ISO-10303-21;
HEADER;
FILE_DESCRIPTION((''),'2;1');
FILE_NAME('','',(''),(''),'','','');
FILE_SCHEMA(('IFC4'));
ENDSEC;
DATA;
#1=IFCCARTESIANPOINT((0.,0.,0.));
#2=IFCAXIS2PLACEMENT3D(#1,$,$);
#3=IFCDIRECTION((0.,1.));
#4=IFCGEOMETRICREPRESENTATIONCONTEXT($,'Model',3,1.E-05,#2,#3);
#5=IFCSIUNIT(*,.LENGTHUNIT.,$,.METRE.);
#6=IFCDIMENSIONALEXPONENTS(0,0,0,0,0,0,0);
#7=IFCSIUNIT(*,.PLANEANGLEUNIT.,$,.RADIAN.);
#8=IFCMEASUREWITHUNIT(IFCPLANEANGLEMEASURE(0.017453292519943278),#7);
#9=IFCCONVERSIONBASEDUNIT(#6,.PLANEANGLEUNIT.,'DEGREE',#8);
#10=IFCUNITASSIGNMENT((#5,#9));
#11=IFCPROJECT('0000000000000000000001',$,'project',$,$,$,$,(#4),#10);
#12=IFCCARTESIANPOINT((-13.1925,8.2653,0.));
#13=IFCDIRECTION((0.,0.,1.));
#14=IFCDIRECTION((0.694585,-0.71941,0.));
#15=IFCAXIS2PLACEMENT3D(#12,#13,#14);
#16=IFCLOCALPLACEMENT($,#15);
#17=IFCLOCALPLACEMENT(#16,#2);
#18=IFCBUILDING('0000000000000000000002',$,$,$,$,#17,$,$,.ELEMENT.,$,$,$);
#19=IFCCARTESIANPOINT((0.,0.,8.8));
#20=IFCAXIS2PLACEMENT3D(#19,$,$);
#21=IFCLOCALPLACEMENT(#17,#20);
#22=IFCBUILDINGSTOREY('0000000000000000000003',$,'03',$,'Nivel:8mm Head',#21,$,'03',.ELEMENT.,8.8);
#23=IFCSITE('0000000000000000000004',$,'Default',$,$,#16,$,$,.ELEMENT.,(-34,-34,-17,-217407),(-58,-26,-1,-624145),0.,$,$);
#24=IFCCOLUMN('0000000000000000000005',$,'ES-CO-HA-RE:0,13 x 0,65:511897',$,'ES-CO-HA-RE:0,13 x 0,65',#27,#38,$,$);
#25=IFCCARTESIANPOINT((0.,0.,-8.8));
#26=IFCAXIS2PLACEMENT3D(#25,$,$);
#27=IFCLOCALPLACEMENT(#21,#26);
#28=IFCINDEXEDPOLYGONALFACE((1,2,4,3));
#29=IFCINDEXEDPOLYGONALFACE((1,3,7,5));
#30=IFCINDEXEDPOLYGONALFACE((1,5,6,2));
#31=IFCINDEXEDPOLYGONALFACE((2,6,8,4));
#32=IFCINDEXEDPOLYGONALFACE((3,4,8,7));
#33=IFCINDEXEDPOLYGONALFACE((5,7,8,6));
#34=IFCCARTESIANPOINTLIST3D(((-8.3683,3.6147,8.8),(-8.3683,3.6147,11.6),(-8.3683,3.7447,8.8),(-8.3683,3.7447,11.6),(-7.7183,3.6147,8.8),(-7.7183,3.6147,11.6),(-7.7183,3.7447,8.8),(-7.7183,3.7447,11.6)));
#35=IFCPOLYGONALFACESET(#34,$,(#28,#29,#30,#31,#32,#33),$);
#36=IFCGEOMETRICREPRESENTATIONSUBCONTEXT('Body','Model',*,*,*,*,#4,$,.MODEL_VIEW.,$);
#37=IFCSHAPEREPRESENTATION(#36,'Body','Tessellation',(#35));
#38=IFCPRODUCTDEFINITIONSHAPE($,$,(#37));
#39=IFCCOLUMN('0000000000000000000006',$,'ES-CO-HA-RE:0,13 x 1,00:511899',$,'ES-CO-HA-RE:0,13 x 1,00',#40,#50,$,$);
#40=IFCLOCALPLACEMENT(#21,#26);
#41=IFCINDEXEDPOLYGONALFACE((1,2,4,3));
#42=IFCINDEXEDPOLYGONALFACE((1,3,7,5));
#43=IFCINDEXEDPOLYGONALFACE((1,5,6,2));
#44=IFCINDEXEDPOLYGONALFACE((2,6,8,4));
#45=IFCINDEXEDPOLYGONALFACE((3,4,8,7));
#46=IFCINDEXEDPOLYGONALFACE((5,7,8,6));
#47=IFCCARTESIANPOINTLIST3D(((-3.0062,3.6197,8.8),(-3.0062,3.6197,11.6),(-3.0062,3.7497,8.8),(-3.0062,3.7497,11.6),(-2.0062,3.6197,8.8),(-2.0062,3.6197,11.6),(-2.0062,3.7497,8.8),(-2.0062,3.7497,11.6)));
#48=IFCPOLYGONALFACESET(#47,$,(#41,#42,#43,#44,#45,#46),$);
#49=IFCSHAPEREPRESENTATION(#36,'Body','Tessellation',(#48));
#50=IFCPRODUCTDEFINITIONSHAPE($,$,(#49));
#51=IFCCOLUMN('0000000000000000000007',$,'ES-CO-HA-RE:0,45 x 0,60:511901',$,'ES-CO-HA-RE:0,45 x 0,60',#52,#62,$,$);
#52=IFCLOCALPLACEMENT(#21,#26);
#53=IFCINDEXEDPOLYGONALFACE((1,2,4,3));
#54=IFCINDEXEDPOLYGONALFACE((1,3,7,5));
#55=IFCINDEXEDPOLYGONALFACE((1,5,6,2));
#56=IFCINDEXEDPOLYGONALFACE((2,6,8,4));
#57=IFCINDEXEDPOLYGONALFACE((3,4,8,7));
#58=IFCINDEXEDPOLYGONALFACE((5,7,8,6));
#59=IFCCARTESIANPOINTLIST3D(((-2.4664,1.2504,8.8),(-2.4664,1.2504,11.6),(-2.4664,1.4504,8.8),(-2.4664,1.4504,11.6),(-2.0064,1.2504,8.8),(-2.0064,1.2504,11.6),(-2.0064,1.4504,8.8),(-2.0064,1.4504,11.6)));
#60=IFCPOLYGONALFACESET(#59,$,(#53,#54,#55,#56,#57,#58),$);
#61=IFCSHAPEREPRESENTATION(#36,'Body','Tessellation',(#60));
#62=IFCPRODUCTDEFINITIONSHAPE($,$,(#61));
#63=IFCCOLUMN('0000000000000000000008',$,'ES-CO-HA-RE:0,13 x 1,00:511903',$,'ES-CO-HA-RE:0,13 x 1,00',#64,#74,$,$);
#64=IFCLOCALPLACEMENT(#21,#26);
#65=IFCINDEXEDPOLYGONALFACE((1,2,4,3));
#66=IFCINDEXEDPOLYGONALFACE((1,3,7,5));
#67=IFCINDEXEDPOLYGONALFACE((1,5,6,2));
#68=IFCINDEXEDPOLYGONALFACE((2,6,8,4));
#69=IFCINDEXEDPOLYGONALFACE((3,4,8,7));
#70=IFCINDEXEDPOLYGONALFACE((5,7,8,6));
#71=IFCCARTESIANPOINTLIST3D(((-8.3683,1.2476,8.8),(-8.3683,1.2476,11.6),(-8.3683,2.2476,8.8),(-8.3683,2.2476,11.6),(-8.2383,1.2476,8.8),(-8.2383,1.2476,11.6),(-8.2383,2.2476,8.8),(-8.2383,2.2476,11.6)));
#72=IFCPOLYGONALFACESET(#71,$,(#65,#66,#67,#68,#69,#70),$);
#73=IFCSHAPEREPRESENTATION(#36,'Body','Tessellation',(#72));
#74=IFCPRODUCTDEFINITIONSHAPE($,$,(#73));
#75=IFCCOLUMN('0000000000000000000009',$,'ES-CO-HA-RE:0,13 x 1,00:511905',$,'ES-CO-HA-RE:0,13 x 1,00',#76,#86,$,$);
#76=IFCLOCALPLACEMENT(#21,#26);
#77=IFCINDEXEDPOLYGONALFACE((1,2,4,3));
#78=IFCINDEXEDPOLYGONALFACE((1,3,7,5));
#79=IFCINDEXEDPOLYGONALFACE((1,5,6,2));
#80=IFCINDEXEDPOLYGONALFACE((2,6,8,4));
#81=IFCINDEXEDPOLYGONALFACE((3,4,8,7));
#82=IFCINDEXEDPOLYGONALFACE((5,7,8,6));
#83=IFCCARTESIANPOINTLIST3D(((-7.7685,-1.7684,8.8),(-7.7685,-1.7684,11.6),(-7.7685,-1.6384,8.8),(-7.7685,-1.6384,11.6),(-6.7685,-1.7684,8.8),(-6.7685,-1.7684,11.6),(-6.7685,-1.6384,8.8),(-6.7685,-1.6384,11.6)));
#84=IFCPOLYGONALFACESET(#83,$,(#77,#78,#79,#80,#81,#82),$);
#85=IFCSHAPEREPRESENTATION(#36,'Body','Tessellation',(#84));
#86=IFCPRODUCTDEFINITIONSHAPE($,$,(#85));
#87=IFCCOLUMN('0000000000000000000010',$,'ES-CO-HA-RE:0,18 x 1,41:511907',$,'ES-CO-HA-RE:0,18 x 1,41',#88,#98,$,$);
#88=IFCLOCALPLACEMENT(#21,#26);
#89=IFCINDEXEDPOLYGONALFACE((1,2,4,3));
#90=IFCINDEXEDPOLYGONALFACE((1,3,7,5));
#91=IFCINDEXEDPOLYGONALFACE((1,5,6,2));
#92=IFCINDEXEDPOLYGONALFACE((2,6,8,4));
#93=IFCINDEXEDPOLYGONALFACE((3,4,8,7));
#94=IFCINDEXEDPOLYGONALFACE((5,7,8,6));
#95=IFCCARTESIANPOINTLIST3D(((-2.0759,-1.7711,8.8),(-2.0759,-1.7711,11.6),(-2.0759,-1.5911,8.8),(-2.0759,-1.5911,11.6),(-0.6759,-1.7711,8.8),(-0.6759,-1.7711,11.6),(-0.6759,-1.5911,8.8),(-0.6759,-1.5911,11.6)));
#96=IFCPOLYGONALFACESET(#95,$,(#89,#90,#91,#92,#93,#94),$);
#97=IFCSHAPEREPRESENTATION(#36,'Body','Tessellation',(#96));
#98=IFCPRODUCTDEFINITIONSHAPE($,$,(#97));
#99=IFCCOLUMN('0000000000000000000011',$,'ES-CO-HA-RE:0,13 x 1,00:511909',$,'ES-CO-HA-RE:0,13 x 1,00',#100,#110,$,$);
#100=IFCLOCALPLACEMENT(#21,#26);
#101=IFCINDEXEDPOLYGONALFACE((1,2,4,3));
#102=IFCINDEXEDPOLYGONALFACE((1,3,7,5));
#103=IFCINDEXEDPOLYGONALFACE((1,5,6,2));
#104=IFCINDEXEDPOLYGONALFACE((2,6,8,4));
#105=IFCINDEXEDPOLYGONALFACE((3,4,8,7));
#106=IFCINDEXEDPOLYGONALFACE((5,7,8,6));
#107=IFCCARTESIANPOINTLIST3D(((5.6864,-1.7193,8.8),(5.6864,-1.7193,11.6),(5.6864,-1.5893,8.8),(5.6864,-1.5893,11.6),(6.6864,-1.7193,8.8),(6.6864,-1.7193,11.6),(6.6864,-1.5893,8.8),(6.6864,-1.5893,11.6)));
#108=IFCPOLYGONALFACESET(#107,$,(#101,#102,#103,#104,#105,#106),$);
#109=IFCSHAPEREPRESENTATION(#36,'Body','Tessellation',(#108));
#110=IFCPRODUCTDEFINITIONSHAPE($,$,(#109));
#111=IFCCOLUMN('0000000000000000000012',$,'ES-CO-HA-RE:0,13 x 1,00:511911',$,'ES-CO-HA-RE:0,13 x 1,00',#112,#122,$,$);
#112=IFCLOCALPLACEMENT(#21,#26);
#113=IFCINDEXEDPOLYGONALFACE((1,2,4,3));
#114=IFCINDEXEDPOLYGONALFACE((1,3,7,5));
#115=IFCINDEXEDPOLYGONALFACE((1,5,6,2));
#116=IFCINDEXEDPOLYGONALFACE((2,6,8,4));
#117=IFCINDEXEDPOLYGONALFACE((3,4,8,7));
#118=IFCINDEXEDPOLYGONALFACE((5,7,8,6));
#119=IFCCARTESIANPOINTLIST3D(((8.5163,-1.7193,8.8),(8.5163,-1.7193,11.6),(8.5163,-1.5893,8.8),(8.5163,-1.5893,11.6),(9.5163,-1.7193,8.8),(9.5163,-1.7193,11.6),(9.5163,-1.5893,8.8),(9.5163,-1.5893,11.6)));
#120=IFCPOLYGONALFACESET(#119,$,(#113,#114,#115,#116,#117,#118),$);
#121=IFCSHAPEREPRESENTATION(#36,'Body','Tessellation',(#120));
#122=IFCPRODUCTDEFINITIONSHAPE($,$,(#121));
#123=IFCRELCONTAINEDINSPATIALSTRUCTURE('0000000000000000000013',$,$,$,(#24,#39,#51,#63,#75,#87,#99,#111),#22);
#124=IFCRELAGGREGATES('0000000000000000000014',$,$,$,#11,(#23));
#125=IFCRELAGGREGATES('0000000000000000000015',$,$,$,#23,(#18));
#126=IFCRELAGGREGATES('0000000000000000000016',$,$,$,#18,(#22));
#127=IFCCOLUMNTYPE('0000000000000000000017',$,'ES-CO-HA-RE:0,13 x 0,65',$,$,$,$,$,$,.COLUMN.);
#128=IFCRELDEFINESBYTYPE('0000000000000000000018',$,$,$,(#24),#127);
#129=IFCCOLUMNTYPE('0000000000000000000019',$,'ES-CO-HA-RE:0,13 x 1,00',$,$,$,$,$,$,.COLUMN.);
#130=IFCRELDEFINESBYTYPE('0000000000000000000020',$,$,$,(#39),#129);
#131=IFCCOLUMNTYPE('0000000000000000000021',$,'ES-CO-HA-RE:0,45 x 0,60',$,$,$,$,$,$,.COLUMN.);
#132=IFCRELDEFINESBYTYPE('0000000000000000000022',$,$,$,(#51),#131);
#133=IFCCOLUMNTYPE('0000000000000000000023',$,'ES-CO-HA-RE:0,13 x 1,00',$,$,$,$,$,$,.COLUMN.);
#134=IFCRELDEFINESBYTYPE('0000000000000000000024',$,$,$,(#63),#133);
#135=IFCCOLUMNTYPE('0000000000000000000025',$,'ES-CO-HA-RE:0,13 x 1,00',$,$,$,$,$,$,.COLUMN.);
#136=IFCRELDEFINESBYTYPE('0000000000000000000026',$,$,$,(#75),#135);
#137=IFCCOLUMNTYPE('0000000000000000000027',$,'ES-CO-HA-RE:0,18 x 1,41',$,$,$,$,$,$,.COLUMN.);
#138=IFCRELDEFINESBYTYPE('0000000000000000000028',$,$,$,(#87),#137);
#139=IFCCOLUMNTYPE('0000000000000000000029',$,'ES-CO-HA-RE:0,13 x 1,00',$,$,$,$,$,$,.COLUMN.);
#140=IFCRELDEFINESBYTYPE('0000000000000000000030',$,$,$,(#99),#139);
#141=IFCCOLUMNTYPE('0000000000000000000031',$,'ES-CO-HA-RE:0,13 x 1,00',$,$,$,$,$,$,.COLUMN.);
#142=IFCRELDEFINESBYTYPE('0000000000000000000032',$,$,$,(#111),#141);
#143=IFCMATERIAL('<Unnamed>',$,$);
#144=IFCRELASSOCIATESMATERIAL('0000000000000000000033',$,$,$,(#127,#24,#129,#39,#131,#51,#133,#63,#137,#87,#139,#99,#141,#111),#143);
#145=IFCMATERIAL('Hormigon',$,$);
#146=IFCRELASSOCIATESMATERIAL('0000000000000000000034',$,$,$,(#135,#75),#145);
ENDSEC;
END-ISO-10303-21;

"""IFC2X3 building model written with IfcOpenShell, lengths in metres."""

from ifc_helpers import new_model, entity, si_unit, converted_unit, direction, frame, frame_2d, origin, origin_2d_with_axis, place, context, subcontext, project, spatial, rectangle, extrude, source, transform, mapped, material, type_object, type_shapes, element, save


model = new_model("IFC2X3")

# Units and contexts
model_context = context("Model", 3, precision=1e-05, world=origin(), true_north=direction((0.0, 1.0)))
body_context = subcontext(model_context, "Body", "Model", "MODEL_VIEW")
ifc_project = project(units=[si_unit("LENGTHUNIT", "METRE"), converted_unit("PLANEANGLEUNIT", "DEGREE", entity("IfcPlaneAngleMeasure", 0.017453292519943278), si_unit("PLANEANGLEUNIT", "RADIAN"), dimensions=[0, 0, 0, 0, 0, 0, 0])], contexts=[model_context])

# Site, building, storey
site_placement = place(None, frame((-13.1925, 8.2653, 0.0), z_axis=(0.0, 0.0, 1.0), x_axis=(0.694585, -0.71941, 0.0)))
site = spatial("IfcSite", under=ifc_project, at=site_placement, Name="Default", CompositionType="ELEMENT", RefLatitude=(-34, -34, -17, -217407), RefLongitude=(-58, -26, -1, -624145), RefElevation=0.0)
building_placement = place(site_placement, origin())
building = spatial("IfcBuilding", under=site, at=building_placement, CompositionType="ELEMENT")
storey_placement = place(building_placement, frame((0.0, 0.0, 8.8)))
storey = spatial("IfcBuildingStorey", under=building, at=storey_placement, Name="03", ObjectType="Nivel:8mm Head", LongName="03", CompositionType="ELEMENT", Elevation=8.8)

# Columns
ifc_material_1 = material(Name="<Unnamed>")
column_type_1 = type_object("IfcColumnType", Name="ES-CO-HA-RE:0,13 x 0,65", PredefinedType="COLUMN", material=ifc_material_1)
shared_shape_1 = source(origin(), body_context, "Body", "SweptSolid", [
    extrude(rectangle(XDim=0.65, YDim=0.13, at=origin_2d_with_axis()), frame((-8.0433, 3.6797, 8.8), z_axis=(0.0, 0.0, 1.0), x_axis=(-1.0, 0.0, 0.0)), (0.0, 0.0, 1.0), 2.8),
])
type_shapes(column_type_1, [shared_shape_1])
column_1_placement = place(storey_placement, frame((0.0, 0.0, -8.8)))
element("IfcColumn", 1, at=column_1_placement, inside=storey, type_object=column_type_1, material=ifc_material_1, Name="ES-CO-HA-RE:0,13 x 0,65:511897", ObjectType="ES-CO-HA-RE:0,13 x 0,65", context=body_context, shape_type="MappedRepresentation", body=[
    mapped(shared_shape_1, transform((0.0, 0.0, 0.0), scale=1.0)),
])
column_type_2 = type_object("IfcColumnType", Name="ES-CO-HA-RE:0,13 x 1,00", PredefinedType="COLUMN", material=ifc_material_1)
shared_shape_2 = source(origin(), body_context, "Body", "SweptSolid", [
    extrude(rectangle(XDim=1.0, YDim=0.13, at=frame_2d((0.0, 0.0), x_axis=(1.0, 0.0))), frame((-2.5062, 3.6847, 8.8), z_axis=(0.0, 0.0, 1.0), x_axis=(-1.0, 0.0, 0.0)), (0.0, 0.0, 1.0), 2.8),
])
type_shapes(column_type_2, [shared_shape_2])
column_2_placement = place(storey_placement, frame((0.0, 0.0, -8.8)))
element("IfcColumn", 2, at=column_2_placement, inside=storey, type_object=column_type_2, material=ifc_material_1, Name="ES-CO-HA-RE:0,13 x 1,00:511899", ObjectType="ES-CO-HA-RE:0,13 x 1,00", context=body_context, shape_type="MappedRepresentation", body=[
    mapped(shared_shape_2, transform((0.0, 0.0, 0.0), scale=1.0)),
])
column_type_3 = type_object("IfcColumnType", Name="ES-CO-HA-RE:0,45 x 0,60", PredefinedType="COLUMN", material=ifc_material_1)
shared_shape_3 = source(origin(), body_context, "Body", "SweptSolid", [
    extrude(rectangle(XDim=0.46, YDim=0.2, at=frame_2d((0.0, 0.0), x_axis=(1.0, 0.0))), frame((-2.2364, 1.3504, 8.8), z_axis=(0.0, 0.0, 1.0), x_axis=(-1.0, 0.0, 0.0)), (0.0, 0.0, 1.0), 2.8),
])
type_shapes(column_type_3, [shared_shape_3])
column_3_placement = place(storey_placement, frame((0.0, 0.0, -8.8)))
element("IfcColumn", 3, at=column_3_placement, inside=storey, type_object=column_type_3, material=ifc_material_1, Name="ES-CO-HA-RE:0,45 x 0,60:511901", ObjectType="ES-CO-HA-RE:0,45 x 0,60", context=body_context, shape_type="MappedRepresentation", body=[
    mapped(shared_shape_3, transform((0.0, 0.0, 0.0), scale=1.0)),
])
column_type_4 = type_object("IfcColumnType", Name="ES-CO-HA-RE:0,13 x 1,00", PredefinedType="COLUMN", material=ifc_material_1)
shared_shape_4 = source(origin(), body_context, "Body", "SweptSolid", [
    extrude(rectangle(XDim=1.0, YDim=0.13, at=frame_2d((0.0, 0.0), x_axis=(1.0, 0.0))), frame((-8.3033, 1.7476, 8.8), z_axis=(0.0, 0.0, 1.0), x_axis=(0.0, -1.0, 0.0)), (0.0, 0.0, 1.0), 2.8),
])
type_shapes(column_type_4, [shared_shape_4])
column_4_placement = place(storey_placement, frame((0.0, 0.0, -8.8)))
element("IfcColumn", 4, at=column_4_placement, inside=storey, type_object=column_type_4, material=ifc_material_1, Name="ES-CO-HA-RE:0,13 x 1,00:511903", ObjectType="ES-CO-HA-RE:0,13 x 1,00", context=body_context, shape_type="MappedRepresentation", body=[
    mapped(shared_shape_4, transform((0.0, 0.0, 0.0), scale=1.0)),
])
ifc_material_2 = material(Name="Hormigon")
column_type_5 = type_object("IfcColumnType", Name="ES-CO-HA-RE:0,13 x 1,00", PredefinedType="COLUMN", material=ifc_material_2)
shared_shape_5 = source(origin(), body_context, "Body", "SweptSolid", [
    extrude(rectangle(XDim=1.0, YDim=0.13, at=frame_2d((0.0, 0.0), x_axis=(1.0, 0.0))), frame((-7.2685, -1.7034, 8.8), z_axis=(0.0, 0.0, 1.0), x_axis=(-1.0, 0.0, 0.0)), (0.0, 0.0, 1.0), 2.8),
])
type_shapes(column_type_5, [shared_shape_5])
column_5_placement = place(storey_placement, frame((0.0, 0.0, -8.8)))
element("IfcColumn", 5, at=column_5_placement, inside=storey, type_object=column_type_5, material=ifc_material_2, Name="ES-CO-HA-RE:0,13 x 1,00:511905", ObjectType="ES-CO-HA-RE:0,13 x 1,00", context=body_context, shape_type="MappedRepresentation", body=[
    mapped(shared_shape_5, transform((0.0, 0.0, 0.0), scale=1.0)),
])
column_type_6 = type_object("IfcColumnType", Name="ES-CO-HA-RE:0,18 x 1,41", PredefinedType="COLUMN", material=ifc_material_1)
shared_shape_6 = source(origin(), body_context, "Body", "SweptSolid", [
    extrude(rectangle(XDim=1.4, YDim=0.18, at=frame_2d((0.0, 0.0), x_axis=(1.0, 0.0))), frame((-1.3759, -1.6811, 8.8), z_axis=(0.0, 0.0, 1.0), x_axis=(-1.0, 0.0, 0.0)), (0.0, 0.0, 1.0), 2.8),
])
type_shapes(column_type_6, [shared_shape_6])
column_6_placement = place(storey_placement, frame((0.0, 0.0, -8.8)))
element("IfcColumn", 6, at=column_6_placement, inside=storey, type_object=column_type_6, material=ifc_material_1, Name="ES-CO-HA-RE:0,18 x 1,41:511907", ObjectType="ES-CO-HA-RE:0,18 x 1,41", context=body_context, shape_type="MappedRepresentation", body=[
    mapped(shared_shape_6, transform((0.0, 0.0, 0.0), scale=1.0)),
])
column_type_7 = type_object("IfcColumnType", Name="ES-CO-HA-RE:0,13 x 1,00", PredefinedType="COLUMN", material=ifc_material_1)
shared_shape_7 = source(origin(), body_context, "Body", "SweptSolid", [
    extrude(rectangle(XDim=1.0, YDim=0.13, at=frame_2d((0.0, 0.0), x_axis=(1.0, 0.0))), frame((6.1864, -1.6543, 8.8), z_axis=(0.0, 0.0, 1.0), x_axis=(-1.0, 0.0, 0.0)), (0.0, 0.0, 1.0), 2.8),
])
type_shapes(column_type_7, [shared_shape_7])
column_7_placement = place(storey_placement, frame((0.0, 0.0, -8.8)))
element("IfcColumn", 7, at=column_7_placement, inside=storey, type_object=column_type_7, material=ifc_material_1, Name="ES-CO-HA-RE:0,13 x 1,00:511909", ObjectType="ES-CO-HA-RE:0,13 x 1,00", context=body_context, shape_type="MappedRepresentation", body=[
    mapped(shared_shape_7, transform((0.0, 0.0, 0.0), scale=1.0)),
])
column_type_8 = type_object("IfcColumnType", Name="ES-CO-HA-RE:0,13 x 1,00", PredefinedType="COLUMN", material=ifc_material_1)
shared_shape_8 = source(origin(), body_context, "Body", "SweptSolid", [
    extrude(rectangle(XDim=1.0, YDim=0.13, at=frame_2d((0.0, 0.0), x_axis=(1.0, 0.0))), frame((9.0163, -1.6543, 8.8), z_axis=(0.0, 0.0, 1.0), x_axis=(-1.0, 0.0, 0.0)), (0.0, 0.0, 1.0), 2.8),
])
type_shapes(column_type_8, [shared_shape_8])
column_8_placement = place(storey_placement, frame((0.0, 0.0, -8.8)))
element("IfcColumn", 8, at=column_8_placement, inside=storey, type_object=column_type_8, material=ifc_material_1, Name="ES-CO-HA-RE:0,13 x 1,00:511911", ObjectType="ES-CO-HA-RE:0,13 x 1,00", context=body_context, shape_type="MappedRepresentation", body=[
    mapped(shared_shape_8, transform((0.0, 0.0, 0.0), scale=1.0)),
])

save(model, "model.ifc")
